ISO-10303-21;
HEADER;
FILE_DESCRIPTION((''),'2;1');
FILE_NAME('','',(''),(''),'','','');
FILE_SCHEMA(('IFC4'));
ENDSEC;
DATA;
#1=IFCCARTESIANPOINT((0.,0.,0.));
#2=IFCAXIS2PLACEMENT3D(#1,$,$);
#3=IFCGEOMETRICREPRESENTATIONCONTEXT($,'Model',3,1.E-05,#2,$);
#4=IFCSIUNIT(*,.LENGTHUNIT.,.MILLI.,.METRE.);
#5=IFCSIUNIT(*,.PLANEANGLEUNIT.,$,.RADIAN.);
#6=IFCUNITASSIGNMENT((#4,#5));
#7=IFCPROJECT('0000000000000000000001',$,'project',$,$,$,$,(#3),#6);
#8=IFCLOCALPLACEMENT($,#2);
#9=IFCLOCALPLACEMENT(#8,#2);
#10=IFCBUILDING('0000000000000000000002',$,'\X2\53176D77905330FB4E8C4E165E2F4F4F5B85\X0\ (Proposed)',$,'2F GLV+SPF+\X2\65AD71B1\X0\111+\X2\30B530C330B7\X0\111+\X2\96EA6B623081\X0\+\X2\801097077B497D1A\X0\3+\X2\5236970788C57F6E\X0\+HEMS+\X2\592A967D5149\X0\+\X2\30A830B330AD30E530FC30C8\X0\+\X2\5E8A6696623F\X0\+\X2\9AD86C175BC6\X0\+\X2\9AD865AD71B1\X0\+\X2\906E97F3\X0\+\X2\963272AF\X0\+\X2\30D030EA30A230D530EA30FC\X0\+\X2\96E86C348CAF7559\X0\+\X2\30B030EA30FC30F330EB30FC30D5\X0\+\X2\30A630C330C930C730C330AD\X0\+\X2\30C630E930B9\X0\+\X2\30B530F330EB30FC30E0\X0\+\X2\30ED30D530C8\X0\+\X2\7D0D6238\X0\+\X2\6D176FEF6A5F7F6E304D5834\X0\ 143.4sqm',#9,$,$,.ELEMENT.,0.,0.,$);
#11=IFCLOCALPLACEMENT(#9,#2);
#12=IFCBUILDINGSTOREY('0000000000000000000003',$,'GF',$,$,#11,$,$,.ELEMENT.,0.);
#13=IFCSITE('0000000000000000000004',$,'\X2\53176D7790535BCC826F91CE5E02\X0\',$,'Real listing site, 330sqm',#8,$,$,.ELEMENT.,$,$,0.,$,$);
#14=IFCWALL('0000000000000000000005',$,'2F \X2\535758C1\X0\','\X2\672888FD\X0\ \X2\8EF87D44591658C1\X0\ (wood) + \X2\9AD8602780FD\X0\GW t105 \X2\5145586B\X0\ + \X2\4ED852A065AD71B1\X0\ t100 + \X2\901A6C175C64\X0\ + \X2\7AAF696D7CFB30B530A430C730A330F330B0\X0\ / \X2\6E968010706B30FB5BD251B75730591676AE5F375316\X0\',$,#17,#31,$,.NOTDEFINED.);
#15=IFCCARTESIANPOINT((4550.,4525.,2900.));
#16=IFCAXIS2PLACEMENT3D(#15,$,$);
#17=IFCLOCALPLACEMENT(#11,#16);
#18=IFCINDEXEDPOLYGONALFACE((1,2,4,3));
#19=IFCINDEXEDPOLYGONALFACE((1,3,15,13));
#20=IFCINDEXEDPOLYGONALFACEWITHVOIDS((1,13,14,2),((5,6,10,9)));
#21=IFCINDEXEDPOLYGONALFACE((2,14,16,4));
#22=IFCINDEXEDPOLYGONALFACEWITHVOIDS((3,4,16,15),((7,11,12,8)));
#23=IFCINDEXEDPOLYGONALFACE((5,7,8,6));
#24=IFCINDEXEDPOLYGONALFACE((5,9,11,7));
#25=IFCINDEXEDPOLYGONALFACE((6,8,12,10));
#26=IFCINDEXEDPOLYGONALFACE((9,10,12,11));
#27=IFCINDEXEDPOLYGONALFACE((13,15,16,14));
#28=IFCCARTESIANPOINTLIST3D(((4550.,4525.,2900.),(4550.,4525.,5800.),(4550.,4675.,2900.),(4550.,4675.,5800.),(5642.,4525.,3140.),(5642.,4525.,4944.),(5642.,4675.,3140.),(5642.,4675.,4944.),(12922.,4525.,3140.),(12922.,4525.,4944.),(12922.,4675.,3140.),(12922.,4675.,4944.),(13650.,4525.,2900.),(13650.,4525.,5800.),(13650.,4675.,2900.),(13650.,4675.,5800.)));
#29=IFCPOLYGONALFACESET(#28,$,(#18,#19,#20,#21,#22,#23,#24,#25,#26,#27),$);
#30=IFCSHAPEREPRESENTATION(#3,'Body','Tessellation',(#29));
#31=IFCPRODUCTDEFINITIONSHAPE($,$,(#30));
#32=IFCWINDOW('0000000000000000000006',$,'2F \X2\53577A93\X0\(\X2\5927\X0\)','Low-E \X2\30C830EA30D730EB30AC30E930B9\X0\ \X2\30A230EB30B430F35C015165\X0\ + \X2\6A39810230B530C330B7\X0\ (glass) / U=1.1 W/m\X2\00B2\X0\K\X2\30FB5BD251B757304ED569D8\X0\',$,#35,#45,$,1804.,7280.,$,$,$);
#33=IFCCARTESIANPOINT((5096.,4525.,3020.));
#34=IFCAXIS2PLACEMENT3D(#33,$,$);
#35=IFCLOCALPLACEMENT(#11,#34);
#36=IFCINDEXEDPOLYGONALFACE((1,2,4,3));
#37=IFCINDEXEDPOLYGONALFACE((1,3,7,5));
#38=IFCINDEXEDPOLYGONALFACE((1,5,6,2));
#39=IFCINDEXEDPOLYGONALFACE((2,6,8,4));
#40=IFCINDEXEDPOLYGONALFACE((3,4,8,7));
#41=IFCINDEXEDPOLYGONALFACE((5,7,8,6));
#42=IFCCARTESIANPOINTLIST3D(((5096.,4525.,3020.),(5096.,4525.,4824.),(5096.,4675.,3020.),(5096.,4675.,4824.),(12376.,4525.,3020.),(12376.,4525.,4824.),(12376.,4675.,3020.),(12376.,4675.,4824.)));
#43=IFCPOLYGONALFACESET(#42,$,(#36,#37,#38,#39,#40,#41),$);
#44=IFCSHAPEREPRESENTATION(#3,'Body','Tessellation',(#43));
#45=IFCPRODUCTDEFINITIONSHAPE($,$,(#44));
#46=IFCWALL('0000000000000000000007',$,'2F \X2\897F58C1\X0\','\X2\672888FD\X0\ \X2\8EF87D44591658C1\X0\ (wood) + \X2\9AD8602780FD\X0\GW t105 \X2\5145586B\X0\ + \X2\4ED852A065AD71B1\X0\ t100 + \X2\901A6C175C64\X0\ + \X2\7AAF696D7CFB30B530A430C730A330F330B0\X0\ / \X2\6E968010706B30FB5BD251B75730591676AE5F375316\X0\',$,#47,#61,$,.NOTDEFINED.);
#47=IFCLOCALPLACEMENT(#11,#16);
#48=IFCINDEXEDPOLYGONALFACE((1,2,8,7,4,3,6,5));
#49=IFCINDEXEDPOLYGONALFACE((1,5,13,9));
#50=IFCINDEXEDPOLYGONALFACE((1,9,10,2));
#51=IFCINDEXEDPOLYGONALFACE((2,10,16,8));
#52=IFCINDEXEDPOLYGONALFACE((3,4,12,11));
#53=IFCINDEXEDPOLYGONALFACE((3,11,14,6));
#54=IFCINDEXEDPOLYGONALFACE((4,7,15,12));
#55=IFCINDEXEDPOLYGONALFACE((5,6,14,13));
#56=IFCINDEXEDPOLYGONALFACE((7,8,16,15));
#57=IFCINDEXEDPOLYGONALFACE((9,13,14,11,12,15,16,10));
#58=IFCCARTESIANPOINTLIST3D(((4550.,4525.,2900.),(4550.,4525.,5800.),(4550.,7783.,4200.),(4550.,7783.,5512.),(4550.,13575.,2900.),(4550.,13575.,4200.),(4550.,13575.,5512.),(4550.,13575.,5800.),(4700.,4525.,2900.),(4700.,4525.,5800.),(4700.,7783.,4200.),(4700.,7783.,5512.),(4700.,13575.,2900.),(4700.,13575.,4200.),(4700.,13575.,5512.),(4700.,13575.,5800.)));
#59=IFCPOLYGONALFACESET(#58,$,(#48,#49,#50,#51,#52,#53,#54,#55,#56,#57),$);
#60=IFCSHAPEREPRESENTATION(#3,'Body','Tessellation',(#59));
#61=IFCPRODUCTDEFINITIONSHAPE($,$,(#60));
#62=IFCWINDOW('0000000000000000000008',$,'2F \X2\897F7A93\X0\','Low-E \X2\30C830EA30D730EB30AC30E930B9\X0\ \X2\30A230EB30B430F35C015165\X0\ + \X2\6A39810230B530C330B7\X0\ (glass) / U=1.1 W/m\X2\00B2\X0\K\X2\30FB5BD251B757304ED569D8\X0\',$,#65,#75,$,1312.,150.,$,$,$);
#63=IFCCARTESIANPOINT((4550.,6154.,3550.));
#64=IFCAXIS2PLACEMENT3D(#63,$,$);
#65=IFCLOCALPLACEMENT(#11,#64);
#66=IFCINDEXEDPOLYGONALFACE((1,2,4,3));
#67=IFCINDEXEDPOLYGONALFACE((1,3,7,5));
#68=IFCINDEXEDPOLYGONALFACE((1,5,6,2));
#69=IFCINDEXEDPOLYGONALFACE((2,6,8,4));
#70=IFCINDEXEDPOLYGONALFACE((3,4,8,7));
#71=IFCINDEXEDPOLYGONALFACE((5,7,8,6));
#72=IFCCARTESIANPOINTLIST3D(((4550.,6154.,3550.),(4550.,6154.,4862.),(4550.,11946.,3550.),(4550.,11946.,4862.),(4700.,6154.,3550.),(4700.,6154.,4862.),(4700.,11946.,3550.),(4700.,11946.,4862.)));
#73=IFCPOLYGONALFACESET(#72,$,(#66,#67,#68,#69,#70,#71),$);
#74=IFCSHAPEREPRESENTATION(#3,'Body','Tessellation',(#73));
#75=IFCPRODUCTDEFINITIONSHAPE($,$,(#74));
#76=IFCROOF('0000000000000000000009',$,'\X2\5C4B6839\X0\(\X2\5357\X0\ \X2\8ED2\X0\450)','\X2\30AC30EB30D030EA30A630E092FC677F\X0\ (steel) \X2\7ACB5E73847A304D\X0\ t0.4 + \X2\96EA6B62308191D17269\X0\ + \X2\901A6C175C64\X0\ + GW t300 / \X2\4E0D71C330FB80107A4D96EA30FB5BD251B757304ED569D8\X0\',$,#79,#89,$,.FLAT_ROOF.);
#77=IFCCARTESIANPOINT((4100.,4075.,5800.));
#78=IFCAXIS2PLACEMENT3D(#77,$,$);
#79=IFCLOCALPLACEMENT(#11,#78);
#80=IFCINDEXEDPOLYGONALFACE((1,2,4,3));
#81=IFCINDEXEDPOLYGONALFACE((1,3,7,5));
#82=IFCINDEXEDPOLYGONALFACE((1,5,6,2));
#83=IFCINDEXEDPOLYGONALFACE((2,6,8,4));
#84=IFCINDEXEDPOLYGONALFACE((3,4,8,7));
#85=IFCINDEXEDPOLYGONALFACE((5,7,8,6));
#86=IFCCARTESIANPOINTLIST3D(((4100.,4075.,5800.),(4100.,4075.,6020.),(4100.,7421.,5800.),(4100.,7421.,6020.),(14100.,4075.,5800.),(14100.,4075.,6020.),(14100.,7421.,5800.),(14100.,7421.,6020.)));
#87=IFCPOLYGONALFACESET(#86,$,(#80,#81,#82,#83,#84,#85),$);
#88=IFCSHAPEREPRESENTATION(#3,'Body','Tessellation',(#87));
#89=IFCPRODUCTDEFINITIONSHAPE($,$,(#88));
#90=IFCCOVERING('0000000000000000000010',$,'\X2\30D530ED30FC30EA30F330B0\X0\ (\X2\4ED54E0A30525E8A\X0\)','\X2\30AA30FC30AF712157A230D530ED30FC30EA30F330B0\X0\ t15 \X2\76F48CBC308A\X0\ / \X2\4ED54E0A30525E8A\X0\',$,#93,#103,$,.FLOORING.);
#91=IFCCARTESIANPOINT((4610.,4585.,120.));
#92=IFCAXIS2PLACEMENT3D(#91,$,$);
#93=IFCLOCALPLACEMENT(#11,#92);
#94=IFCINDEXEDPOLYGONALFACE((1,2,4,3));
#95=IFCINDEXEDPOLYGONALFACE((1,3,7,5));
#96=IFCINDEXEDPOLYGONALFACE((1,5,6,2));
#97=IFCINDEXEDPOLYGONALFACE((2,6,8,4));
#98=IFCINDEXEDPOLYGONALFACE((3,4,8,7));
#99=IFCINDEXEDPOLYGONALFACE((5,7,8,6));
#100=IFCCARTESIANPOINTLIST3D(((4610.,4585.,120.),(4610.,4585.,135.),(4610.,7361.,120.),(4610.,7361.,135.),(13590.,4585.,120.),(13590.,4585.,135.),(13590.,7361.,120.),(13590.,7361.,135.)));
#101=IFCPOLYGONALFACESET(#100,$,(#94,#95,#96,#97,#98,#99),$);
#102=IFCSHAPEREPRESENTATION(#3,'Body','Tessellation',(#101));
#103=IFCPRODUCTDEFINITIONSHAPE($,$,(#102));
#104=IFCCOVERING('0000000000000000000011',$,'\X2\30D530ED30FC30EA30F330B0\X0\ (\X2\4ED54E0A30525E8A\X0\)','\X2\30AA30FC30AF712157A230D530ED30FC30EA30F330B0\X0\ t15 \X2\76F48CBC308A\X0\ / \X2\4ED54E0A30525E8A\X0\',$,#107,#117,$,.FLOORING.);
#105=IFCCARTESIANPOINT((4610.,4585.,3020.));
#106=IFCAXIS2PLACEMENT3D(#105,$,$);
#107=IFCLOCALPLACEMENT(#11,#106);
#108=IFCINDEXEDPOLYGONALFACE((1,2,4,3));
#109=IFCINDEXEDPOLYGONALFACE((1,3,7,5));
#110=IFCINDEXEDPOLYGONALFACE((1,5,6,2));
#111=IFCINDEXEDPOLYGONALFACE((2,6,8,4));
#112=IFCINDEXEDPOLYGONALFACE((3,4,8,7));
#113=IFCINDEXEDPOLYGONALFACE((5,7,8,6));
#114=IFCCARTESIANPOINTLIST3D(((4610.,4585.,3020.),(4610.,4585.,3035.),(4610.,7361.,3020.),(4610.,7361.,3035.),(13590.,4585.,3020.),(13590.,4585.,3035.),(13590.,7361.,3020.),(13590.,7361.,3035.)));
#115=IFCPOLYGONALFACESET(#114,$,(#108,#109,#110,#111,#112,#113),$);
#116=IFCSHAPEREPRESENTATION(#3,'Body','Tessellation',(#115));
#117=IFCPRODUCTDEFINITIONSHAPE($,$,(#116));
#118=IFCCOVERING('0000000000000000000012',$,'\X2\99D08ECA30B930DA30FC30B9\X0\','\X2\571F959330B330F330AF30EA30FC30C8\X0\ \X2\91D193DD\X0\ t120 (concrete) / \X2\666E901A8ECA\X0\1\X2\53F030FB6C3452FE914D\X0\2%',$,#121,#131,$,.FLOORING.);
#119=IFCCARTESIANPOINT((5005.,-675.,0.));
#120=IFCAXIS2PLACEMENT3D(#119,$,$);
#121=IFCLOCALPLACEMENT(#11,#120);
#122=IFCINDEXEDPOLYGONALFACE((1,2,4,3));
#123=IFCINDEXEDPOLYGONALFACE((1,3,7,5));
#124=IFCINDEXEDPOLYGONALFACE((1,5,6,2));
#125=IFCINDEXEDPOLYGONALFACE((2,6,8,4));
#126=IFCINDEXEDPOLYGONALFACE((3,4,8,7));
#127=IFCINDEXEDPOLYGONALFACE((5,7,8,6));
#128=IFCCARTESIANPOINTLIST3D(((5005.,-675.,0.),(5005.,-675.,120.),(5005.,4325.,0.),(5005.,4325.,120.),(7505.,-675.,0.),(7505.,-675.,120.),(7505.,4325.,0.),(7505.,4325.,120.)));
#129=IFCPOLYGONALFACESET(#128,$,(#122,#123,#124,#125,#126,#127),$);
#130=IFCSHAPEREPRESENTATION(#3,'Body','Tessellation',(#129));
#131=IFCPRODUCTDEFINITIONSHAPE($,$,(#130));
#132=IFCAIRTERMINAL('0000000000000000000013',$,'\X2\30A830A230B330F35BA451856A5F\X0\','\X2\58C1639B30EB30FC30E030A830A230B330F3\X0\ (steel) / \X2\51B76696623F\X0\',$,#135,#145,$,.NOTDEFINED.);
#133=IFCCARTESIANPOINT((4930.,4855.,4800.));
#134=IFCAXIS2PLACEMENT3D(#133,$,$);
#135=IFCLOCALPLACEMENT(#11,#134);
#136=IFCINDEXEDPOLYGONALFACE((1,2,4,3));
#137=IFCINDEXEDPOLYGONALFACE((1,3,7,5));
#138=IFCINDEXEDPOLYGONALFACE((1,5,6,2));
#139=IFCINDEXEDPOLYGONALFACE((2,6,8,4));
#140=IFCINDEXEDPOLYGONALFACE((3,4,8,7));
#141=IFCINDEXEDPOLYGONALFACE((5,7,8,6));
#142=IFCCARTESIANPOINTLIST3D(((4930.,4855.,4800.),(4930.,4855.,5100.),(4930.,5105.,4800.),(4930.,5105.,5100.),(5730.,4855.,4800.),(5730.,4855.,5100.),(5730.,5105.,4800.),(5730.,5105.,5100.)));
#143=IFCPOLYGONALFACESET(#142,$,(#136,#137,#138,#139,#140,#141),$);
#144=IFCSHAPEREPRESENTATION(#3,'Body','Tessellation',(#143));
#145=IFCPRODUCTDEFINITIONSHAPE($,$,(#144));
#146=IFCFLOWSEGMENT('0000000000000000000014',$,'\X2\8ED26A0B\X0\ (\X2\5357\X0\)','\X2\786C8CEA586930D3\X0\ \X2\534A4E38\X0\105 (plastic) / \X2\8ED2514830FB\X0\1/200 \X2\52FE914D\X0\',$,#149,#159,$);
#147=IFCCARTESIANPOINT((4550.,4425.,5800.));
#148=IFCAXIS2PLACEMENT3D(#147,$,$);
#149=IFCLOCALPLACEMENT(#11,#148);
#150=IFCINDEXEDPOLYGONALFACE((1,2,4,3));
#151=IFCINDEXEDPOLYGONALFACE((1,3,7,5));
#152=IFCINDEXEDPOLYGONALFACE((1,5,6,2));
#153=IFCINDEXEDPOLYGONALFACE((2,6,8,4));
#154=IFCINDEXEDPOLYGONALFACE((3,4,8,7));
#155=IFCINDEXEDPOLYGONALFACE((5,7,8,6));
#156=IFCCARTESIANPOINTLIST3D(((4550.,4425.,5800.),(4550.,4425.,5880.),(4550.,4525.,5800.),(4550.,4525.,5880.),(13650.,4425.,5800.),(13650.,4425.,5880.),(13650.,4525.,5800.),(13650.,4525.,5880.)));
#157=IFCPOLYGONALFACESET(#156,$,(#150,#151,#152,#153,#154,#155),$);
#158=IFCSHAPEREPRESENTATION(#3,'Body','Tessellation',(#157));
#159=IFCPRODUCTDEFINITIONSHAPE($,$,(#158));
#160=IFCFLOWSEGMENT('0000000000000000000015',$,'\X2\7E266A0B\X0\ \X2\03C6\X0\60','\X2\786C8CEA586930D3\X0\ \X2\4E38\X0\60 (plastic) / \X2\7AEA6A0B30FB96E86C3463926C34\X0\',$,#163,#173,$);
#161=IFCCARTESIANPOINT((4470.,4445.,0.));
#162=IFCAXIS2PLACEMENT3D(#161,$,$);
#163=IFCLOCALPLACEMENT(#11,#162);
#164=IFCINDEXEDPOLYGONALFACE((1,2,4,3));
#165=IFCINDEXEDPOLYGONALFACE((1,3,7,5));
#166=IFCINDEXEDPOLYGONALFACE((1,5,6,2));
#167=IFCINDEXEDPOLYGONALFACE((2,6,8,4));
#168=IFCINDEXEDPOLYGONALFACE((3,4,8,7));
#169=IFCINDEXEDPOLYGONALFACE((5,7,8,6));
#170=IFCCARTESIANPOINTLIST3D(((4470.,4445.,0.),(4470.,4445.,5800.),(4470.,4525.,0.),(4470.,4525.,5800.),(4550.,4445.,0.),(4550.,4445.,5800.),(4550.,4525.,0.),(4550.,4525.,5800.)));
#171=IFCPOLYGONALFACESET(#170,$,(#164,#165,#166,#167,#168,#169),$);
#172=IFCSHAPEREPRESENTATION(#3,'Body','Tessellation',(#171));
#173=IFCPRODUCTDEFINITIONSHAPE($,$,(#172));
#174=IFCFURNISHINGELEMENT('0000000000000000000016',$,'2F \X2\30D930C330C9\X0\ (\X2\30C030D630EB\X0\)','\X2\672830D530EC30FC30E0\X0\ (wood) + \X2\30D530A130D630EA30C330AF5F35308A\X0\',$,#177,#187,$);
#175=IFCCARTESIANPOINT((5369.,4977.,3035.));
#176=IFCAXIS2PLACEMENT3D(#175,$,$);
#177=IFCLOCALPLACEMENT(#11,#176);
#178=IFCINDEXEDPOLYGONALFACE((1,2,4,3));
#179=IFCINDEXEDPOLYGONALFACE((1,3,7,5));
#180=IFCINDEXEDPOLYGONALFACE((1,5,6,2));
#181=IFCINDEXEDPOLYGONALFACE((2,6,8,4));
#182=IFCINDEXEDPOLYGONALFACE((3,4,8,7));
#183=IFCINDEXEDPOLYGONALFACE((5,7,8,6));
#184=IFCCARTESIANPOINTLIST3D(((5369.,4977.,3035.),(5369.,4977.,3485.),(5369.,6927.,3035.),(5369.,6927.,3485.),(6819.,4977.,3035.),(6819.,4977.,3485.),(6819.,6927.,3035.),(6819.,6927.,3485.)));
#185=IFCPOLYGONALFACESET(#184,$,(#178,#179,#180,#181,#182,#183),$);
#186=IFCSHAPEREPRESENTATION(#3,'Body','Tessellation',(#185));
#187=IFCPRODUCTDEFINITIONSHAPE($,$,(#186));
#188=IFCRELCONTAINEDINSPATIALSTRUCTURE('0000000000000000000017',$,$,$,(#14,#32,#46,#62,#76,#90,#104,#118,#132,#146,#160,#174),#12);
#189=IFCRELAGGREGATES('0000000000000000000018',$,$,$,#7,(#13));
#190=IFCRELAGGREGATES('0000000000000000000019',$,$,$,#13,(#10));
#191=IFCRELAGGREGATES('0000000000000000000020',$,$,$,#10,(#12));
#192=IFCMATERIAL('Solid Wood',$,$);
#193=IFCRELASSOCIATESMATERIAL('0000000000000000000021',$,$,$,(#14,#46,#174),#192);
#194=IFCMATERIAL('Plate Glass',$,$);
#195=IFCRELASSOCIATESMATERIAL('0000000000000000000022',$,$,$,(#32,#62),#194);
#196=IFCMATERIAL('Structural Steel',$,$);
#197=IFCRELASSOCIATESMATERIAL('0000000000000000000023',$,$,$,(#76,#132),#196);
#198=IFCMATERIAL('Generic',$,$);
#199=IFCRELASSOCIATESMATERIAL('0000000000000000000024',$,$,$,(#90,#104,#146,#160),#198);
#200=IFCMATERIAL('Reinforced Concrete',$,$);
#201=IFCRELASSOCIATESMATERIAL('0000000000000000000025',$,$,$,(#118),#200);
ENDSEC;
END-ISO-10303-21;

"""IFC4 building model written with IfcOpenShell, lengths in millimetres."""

from ifc_helpers import new_model, si_unit, frame, frame_2d, origin, place, context, project, spatial, rectangle, extrude, material, element, fill, save


model = new_model("IFC4")

# Units and contexts
model_context = context("Model", 3, precision=1e-05, world=origin())
ifc_project = project(units=[si_unit("LENGTHUNIT", "METRE", prefix="MILLI"), si_unit("PLANEANGLEUNIT", "RADIAN")], contexts=[model_context])

# Site, building, storey
site_placement = place(None, origin())
site = spatial("IfcSite", under=ifc_project, at=site_placement, Name="北海道富良野市", ObjectType="Real listing site, 330sqm", CompositionType="ELEMENT", RefElevation=0.0)
building_placement = place(site_placement, origin())
building = spatial("IfcBuilding", under=site, at=building_placement, Name="北海道・二世帯住宅 (Proposed)", ObjectType="2F GLV+SPF+断熱111+サッシ111+雪止め+耐震等級3+制震装置+HEMS+太陽光+エコキュート+床暖房+高気密+高断熱+遮音+防犯+バリアフリー+雨水貯留+グリーンルーフ+ウッドデッキ+テラス+サンルーム+ロフト+納戸+洗濯機置き場 143.4sqm", CompositionType="ELEMENT", ElevationOfRefHeight=0.0, ElevationOfTerrain=0.0)
storey_placement = place(building_placement, origin())
storey = spatial("IfcBuildingStorey", under=building, at=storey_placement, Name="GF", CompositionType="ELEMENT", Elevation=0.0)

# Shared definitions
ifc_material_1 = material(Name="Solid Wood")

# Shared definitions
ifc_material_2 = material(Name="Reinforced Concrete")

# Shared definitions
ifc_material_3 = material(Name="Plate Glass")

# Walls, openings, windows
wall_1_placement = place(storey_placement, frame((4550.0, 4525.0, 2900.0)))
wall_1 = element("IfcWall", 1, at=wall_1_placement, inside=storey, material=ifc_material_1, Name="2F 南壁", Description="木製 軸組外壁 (wood) + 高性能GW t105 充填 + 付加断熱 t100 + 通気層 + 窯業系サイディング / 準耐火・寒冷地外皮強化", PredefinedType="NOTDEFINED", context=model_context, shape_type="SweptSolid", body=[
    extrude(rectangle(XDim=9100.0, YDim=150.0, at=frame_2d((4550.0, 75.0))), frame((4550.0, 4525.0, 2900.0)), (0.0, 0.0, 1.0), 2900.0),
])
opening_1_placement = place(storey_placement, frame((5096.0, 4525.0, 3020.0)))
opening_1 = element("IfcOpeningElement", 2, at=opening_1_placement, cuts=wall_1, PredefinedType="NOTDEFINED", context=model_context, shape_type="SweptSolid", body=[
    extrude(rectangle(XDim=7280.0, YDim=150.0, at=frame_2d((3640.0, 75.0))), frame((5096.0, 4525.0, 3020.0)), (0.0, 0.0, 1.0), 1804.0),
])
window_1_placement = place(storey_placement, frame((5096.0, 4525.0, 3020.0)))
window_1 = element("IfcWindow", 3, at=window_1_placement, inside=storey, material=ifc_material_3, Name="2F 南窓(大)", Description="Low-E トリプルガラス アルゴン封入 + 樹脂サッシ (glass) / U=1.1 W/m²K・寒冷地仕様", OverallHeight=1804.0, OverallWidth=7280.0, context=model_context, shape_type="SweptSolid", body=[
    extrude(rectangle(XDim=7280.0, YDim=150.0, at=frame_2d((3640.0, 75.0))), frame((5096.0, 4525.0, 3020.0)), (0.0, 0.0, 1.0), 1804.0),
])
fill(opening_1, window_1)
wall_2_placement = place(storey_placement, frame((4550.0, 4525.0, 2900.0)))
wall_2 = element("IfcWall", 4, at=wall_2_placement, inside=storey, material=ifc_material_1, Name="2F 西壁", Description="木製 軸組外壁 (wood) + 高性能GW t105 充填 + 付加断熱 t100 + 通気層 + 窯業系サイディング / 準耐火・寒冷地外皮強化", PredefinedType="NOTDEFINED", context=model_context, shape_type="SweptSolid", body=[
    extrude(rectangle(XDim=150.0, YDim=9050.0, at=frame_2d((75.0, 4525.0))), frame((4550.0, 4525.0, 2900.0)), (0.0, 0.0, 1.0), 2900.0),
])
opening_2_placement = place(storey_placement, frame((4550.0, 6154.0, 3550.0)))
opening_2 = element("IfcOpeningElement", 5, at=opening_2_placement, cuts=wall_2, PredefinedType="NOTDEFINED", context=model_context, shape_type="SweptSolid", body=[
    extrude(rectangle(XDim=150.0, YDim=5792.0, at=frame_2d((75.0, 2896.0))), frame((4550.0, 6154.0, 3550.0)), (0.0, 0.0, 1.0), 1312.0),
])
window_2_placement = place(storey_placement, frame((4550.0, 6154.0, 3550.0)))
window_2 = element("IfcWindow", 6, at=window_2_placement, inside=storey, material=ifc_material_3, Name="2F 西窓", Description="Low-E トリプルガラス アルゴン封入 + 樹脂サッシ (glass) / U=1.1 W/m²K・寒冷地仕様", OverallHeight=1312.0, OverallWidth=150.0, context=model_context, shape_type="SweptSolid", body=[
    extrude(rectangle(XDim=150.0, YDim=5792.0, at=frame_2d((75.0, 2896.0))), frame((4550.0, 6154.0, 3550.0)), (0.0, 0.0, 1.0), 1312.0),
])
fill(opening_2, window_2)

# Roof
ifc_material_4 = material(Name="Structural Steel")
for number, where, name in (
    (7, (4100.0, 4075.0, 5800.0), "屋根(南 軒450)"),
):
    element("IfcRoof", number, at=place(storey_placement, frame(where)), inside=storey, material=ifc_material_4, Name=name, Description="ガルバリウム鋼板 (steel) 立平葺き t0.4 + 雪止め金物 + 通気層 + GW t300 / 不燃・耐積雪・寒冷地仕様", PredefinedType="FLAT_ROOF", context=model_context, shape_type="SweptSolid", body=[
        extrude(rectangle(XDim=10000.0, YDim=3346.0, at=frame_2d((5000.0, 1673.0))), frame((4100.0, 4075.0, 5800.0)), (0.0, 0.0, 1.0), 220.0),
    ])

# Coverings
ifc_material_5 = material(Name="Generic")
covering_1_placement = place(storey_placement, frame((4610.0, 4585.0, 120.0)))
element("IfcCovering", 8, at=covering_1_placement, inside=storey, material=ifc_material_5, Name="フローリング (仕上げ床)", Description="オーク無垢フローリング t15 直貼り / 仕上げ床", PredefinedType="FLOORING", context=model_context, shape_type="SweptSolid", body=[
    extrude(rectangle(XDim=8980.0, YDim=2776.0, at=frame_2d((4490.0, 1388.0))), frame((4610.0, 4585.0, 120.0)), (0.0, 0.0, 1.0), 15.0),
])
covering_2_placement = place(storey_placement, frame((4610.0, 4585.0, 3020.0)))
element("IfcCovering", 9, at=covering_2_placement, inside=storey, material=ifc_material_5, Name="フローリング (仕上げ床)", Description="オーク無垢フローリング t15 直貼り / 仕上げ床", PredefinedType="FLOORING", context=model_context, shape_type="SweptSolid", body=[
    extrude(rectangle(XDim=8980.0, YDim=2776.0, at=frame_2d((4490.0, 1388.0))), frame((4610.0, 4585.0, 3020.0)), (0.0, 0.0, 1.0), 15.0),
])
covering_3_placement = place(storey_placement, frame((5005.0, -675.0, 0.0)))
element("IfcCovering", 10, at=covering_3_placement, inside=storey, material=ifc_material_2, Name="駐車スペース", Description="土間コンクリート 金鏝 t120 (concrete) / 普通車1台・水勾配2%", PredefinedType="FLOORING", context=model_context, shape_type="SweptSolid", body=[
    extrude(rectangle(XDim=2500.0, YDim=5000.0, at=frame_2d((1250.0, 2500.0))), frame((5005.0, -675.0, 0.0)), (0.0, 0.0, 1.0), 120.0),
])

# Air terminal
air_terminal_placement = place(storey_placement, frame((4930.0, 4855.0, 4800.0)))
element("IfcAirTerminal", 11, at=air_terminal_placement, inside=storey, material=ifc_material_4, Name="エアコン室内機", Description="壁掛ルームエアコン (steel) / 冷暖房", PredefinedType="NOTDEFINED", context=model_context, shape_type="SweptSolid", body=[
    extrude(rectangle(XDim=800.0, YDim=250.0, at=frame_2d((400.0, 125.0))), frame((4930.0, 4855.0, 4800.0)), (0.0, 0.0, 1.0), 300.0),
])

# Flow segments
flow_segment_1_placement = place(storey_placement, frame((4550.0, 4425.0, 5800.0)))
element("IfcFlowSegment", 12, at=flow_segment_1_placement, inside=storey, material=ifc_material_5, Name="軒樋 (南)", Description="硬質塩ビ 半丸105 (plastic) / 軒先・1/200 勾配", context=model_context, shape_type="SweptSolid", body=[
    extrude(rectangle(XDim=9100.0, YDim=100.0, at=frame_2d((4550.0, 50.0))), frame((4550.0, 4425.0, 5800.0)), (0.0, 0.0, 1.0), 80.0),
])
flow_segment_2_placement = place(storey_placement, frame((4470.0, 4445.0, 0.0)))
element("IfcFlowSegment", 13, at=flow_segment_2_placement, inside=storey, material=ifc_material_5, Name="縦樋 φ60", Description="硬質塩ビ 丸60 (plastic) / 竪樋・雨水排水", context=model_context, shape_type="SweptSolid", body=[
    extrude(rectangle(XDim=80.0, YDim=80.0, at=frame_2d((40.0, 40.0))), frame((4470.0, 4445.0, 0.0)), (0.0, 0.0, 1.0), 5800.0),
])

# Furnishing element
furnishing_placement = place(storey_placement, frame((5369.0, 4977.0, 3035.0)))
element("IfcFurnishingElement", 14, at=furnishing_placement, inside=storey, material=ifc_material_1, Name="2F ベッド (ダブル)", Description="木フレーム (wood) + ファブリック張り", context=model_context, shape_type="SweptSolid", body=[
    extrude(rectangle(XDim=1450.0, YDim=1950.0, at=frame_2d((725.0, 975.0))), frame((5369.0, 4977.0, 3035.0)), (0.0, 0.0, 1.0), 450.0),
])

save(model, "model.ifc")
